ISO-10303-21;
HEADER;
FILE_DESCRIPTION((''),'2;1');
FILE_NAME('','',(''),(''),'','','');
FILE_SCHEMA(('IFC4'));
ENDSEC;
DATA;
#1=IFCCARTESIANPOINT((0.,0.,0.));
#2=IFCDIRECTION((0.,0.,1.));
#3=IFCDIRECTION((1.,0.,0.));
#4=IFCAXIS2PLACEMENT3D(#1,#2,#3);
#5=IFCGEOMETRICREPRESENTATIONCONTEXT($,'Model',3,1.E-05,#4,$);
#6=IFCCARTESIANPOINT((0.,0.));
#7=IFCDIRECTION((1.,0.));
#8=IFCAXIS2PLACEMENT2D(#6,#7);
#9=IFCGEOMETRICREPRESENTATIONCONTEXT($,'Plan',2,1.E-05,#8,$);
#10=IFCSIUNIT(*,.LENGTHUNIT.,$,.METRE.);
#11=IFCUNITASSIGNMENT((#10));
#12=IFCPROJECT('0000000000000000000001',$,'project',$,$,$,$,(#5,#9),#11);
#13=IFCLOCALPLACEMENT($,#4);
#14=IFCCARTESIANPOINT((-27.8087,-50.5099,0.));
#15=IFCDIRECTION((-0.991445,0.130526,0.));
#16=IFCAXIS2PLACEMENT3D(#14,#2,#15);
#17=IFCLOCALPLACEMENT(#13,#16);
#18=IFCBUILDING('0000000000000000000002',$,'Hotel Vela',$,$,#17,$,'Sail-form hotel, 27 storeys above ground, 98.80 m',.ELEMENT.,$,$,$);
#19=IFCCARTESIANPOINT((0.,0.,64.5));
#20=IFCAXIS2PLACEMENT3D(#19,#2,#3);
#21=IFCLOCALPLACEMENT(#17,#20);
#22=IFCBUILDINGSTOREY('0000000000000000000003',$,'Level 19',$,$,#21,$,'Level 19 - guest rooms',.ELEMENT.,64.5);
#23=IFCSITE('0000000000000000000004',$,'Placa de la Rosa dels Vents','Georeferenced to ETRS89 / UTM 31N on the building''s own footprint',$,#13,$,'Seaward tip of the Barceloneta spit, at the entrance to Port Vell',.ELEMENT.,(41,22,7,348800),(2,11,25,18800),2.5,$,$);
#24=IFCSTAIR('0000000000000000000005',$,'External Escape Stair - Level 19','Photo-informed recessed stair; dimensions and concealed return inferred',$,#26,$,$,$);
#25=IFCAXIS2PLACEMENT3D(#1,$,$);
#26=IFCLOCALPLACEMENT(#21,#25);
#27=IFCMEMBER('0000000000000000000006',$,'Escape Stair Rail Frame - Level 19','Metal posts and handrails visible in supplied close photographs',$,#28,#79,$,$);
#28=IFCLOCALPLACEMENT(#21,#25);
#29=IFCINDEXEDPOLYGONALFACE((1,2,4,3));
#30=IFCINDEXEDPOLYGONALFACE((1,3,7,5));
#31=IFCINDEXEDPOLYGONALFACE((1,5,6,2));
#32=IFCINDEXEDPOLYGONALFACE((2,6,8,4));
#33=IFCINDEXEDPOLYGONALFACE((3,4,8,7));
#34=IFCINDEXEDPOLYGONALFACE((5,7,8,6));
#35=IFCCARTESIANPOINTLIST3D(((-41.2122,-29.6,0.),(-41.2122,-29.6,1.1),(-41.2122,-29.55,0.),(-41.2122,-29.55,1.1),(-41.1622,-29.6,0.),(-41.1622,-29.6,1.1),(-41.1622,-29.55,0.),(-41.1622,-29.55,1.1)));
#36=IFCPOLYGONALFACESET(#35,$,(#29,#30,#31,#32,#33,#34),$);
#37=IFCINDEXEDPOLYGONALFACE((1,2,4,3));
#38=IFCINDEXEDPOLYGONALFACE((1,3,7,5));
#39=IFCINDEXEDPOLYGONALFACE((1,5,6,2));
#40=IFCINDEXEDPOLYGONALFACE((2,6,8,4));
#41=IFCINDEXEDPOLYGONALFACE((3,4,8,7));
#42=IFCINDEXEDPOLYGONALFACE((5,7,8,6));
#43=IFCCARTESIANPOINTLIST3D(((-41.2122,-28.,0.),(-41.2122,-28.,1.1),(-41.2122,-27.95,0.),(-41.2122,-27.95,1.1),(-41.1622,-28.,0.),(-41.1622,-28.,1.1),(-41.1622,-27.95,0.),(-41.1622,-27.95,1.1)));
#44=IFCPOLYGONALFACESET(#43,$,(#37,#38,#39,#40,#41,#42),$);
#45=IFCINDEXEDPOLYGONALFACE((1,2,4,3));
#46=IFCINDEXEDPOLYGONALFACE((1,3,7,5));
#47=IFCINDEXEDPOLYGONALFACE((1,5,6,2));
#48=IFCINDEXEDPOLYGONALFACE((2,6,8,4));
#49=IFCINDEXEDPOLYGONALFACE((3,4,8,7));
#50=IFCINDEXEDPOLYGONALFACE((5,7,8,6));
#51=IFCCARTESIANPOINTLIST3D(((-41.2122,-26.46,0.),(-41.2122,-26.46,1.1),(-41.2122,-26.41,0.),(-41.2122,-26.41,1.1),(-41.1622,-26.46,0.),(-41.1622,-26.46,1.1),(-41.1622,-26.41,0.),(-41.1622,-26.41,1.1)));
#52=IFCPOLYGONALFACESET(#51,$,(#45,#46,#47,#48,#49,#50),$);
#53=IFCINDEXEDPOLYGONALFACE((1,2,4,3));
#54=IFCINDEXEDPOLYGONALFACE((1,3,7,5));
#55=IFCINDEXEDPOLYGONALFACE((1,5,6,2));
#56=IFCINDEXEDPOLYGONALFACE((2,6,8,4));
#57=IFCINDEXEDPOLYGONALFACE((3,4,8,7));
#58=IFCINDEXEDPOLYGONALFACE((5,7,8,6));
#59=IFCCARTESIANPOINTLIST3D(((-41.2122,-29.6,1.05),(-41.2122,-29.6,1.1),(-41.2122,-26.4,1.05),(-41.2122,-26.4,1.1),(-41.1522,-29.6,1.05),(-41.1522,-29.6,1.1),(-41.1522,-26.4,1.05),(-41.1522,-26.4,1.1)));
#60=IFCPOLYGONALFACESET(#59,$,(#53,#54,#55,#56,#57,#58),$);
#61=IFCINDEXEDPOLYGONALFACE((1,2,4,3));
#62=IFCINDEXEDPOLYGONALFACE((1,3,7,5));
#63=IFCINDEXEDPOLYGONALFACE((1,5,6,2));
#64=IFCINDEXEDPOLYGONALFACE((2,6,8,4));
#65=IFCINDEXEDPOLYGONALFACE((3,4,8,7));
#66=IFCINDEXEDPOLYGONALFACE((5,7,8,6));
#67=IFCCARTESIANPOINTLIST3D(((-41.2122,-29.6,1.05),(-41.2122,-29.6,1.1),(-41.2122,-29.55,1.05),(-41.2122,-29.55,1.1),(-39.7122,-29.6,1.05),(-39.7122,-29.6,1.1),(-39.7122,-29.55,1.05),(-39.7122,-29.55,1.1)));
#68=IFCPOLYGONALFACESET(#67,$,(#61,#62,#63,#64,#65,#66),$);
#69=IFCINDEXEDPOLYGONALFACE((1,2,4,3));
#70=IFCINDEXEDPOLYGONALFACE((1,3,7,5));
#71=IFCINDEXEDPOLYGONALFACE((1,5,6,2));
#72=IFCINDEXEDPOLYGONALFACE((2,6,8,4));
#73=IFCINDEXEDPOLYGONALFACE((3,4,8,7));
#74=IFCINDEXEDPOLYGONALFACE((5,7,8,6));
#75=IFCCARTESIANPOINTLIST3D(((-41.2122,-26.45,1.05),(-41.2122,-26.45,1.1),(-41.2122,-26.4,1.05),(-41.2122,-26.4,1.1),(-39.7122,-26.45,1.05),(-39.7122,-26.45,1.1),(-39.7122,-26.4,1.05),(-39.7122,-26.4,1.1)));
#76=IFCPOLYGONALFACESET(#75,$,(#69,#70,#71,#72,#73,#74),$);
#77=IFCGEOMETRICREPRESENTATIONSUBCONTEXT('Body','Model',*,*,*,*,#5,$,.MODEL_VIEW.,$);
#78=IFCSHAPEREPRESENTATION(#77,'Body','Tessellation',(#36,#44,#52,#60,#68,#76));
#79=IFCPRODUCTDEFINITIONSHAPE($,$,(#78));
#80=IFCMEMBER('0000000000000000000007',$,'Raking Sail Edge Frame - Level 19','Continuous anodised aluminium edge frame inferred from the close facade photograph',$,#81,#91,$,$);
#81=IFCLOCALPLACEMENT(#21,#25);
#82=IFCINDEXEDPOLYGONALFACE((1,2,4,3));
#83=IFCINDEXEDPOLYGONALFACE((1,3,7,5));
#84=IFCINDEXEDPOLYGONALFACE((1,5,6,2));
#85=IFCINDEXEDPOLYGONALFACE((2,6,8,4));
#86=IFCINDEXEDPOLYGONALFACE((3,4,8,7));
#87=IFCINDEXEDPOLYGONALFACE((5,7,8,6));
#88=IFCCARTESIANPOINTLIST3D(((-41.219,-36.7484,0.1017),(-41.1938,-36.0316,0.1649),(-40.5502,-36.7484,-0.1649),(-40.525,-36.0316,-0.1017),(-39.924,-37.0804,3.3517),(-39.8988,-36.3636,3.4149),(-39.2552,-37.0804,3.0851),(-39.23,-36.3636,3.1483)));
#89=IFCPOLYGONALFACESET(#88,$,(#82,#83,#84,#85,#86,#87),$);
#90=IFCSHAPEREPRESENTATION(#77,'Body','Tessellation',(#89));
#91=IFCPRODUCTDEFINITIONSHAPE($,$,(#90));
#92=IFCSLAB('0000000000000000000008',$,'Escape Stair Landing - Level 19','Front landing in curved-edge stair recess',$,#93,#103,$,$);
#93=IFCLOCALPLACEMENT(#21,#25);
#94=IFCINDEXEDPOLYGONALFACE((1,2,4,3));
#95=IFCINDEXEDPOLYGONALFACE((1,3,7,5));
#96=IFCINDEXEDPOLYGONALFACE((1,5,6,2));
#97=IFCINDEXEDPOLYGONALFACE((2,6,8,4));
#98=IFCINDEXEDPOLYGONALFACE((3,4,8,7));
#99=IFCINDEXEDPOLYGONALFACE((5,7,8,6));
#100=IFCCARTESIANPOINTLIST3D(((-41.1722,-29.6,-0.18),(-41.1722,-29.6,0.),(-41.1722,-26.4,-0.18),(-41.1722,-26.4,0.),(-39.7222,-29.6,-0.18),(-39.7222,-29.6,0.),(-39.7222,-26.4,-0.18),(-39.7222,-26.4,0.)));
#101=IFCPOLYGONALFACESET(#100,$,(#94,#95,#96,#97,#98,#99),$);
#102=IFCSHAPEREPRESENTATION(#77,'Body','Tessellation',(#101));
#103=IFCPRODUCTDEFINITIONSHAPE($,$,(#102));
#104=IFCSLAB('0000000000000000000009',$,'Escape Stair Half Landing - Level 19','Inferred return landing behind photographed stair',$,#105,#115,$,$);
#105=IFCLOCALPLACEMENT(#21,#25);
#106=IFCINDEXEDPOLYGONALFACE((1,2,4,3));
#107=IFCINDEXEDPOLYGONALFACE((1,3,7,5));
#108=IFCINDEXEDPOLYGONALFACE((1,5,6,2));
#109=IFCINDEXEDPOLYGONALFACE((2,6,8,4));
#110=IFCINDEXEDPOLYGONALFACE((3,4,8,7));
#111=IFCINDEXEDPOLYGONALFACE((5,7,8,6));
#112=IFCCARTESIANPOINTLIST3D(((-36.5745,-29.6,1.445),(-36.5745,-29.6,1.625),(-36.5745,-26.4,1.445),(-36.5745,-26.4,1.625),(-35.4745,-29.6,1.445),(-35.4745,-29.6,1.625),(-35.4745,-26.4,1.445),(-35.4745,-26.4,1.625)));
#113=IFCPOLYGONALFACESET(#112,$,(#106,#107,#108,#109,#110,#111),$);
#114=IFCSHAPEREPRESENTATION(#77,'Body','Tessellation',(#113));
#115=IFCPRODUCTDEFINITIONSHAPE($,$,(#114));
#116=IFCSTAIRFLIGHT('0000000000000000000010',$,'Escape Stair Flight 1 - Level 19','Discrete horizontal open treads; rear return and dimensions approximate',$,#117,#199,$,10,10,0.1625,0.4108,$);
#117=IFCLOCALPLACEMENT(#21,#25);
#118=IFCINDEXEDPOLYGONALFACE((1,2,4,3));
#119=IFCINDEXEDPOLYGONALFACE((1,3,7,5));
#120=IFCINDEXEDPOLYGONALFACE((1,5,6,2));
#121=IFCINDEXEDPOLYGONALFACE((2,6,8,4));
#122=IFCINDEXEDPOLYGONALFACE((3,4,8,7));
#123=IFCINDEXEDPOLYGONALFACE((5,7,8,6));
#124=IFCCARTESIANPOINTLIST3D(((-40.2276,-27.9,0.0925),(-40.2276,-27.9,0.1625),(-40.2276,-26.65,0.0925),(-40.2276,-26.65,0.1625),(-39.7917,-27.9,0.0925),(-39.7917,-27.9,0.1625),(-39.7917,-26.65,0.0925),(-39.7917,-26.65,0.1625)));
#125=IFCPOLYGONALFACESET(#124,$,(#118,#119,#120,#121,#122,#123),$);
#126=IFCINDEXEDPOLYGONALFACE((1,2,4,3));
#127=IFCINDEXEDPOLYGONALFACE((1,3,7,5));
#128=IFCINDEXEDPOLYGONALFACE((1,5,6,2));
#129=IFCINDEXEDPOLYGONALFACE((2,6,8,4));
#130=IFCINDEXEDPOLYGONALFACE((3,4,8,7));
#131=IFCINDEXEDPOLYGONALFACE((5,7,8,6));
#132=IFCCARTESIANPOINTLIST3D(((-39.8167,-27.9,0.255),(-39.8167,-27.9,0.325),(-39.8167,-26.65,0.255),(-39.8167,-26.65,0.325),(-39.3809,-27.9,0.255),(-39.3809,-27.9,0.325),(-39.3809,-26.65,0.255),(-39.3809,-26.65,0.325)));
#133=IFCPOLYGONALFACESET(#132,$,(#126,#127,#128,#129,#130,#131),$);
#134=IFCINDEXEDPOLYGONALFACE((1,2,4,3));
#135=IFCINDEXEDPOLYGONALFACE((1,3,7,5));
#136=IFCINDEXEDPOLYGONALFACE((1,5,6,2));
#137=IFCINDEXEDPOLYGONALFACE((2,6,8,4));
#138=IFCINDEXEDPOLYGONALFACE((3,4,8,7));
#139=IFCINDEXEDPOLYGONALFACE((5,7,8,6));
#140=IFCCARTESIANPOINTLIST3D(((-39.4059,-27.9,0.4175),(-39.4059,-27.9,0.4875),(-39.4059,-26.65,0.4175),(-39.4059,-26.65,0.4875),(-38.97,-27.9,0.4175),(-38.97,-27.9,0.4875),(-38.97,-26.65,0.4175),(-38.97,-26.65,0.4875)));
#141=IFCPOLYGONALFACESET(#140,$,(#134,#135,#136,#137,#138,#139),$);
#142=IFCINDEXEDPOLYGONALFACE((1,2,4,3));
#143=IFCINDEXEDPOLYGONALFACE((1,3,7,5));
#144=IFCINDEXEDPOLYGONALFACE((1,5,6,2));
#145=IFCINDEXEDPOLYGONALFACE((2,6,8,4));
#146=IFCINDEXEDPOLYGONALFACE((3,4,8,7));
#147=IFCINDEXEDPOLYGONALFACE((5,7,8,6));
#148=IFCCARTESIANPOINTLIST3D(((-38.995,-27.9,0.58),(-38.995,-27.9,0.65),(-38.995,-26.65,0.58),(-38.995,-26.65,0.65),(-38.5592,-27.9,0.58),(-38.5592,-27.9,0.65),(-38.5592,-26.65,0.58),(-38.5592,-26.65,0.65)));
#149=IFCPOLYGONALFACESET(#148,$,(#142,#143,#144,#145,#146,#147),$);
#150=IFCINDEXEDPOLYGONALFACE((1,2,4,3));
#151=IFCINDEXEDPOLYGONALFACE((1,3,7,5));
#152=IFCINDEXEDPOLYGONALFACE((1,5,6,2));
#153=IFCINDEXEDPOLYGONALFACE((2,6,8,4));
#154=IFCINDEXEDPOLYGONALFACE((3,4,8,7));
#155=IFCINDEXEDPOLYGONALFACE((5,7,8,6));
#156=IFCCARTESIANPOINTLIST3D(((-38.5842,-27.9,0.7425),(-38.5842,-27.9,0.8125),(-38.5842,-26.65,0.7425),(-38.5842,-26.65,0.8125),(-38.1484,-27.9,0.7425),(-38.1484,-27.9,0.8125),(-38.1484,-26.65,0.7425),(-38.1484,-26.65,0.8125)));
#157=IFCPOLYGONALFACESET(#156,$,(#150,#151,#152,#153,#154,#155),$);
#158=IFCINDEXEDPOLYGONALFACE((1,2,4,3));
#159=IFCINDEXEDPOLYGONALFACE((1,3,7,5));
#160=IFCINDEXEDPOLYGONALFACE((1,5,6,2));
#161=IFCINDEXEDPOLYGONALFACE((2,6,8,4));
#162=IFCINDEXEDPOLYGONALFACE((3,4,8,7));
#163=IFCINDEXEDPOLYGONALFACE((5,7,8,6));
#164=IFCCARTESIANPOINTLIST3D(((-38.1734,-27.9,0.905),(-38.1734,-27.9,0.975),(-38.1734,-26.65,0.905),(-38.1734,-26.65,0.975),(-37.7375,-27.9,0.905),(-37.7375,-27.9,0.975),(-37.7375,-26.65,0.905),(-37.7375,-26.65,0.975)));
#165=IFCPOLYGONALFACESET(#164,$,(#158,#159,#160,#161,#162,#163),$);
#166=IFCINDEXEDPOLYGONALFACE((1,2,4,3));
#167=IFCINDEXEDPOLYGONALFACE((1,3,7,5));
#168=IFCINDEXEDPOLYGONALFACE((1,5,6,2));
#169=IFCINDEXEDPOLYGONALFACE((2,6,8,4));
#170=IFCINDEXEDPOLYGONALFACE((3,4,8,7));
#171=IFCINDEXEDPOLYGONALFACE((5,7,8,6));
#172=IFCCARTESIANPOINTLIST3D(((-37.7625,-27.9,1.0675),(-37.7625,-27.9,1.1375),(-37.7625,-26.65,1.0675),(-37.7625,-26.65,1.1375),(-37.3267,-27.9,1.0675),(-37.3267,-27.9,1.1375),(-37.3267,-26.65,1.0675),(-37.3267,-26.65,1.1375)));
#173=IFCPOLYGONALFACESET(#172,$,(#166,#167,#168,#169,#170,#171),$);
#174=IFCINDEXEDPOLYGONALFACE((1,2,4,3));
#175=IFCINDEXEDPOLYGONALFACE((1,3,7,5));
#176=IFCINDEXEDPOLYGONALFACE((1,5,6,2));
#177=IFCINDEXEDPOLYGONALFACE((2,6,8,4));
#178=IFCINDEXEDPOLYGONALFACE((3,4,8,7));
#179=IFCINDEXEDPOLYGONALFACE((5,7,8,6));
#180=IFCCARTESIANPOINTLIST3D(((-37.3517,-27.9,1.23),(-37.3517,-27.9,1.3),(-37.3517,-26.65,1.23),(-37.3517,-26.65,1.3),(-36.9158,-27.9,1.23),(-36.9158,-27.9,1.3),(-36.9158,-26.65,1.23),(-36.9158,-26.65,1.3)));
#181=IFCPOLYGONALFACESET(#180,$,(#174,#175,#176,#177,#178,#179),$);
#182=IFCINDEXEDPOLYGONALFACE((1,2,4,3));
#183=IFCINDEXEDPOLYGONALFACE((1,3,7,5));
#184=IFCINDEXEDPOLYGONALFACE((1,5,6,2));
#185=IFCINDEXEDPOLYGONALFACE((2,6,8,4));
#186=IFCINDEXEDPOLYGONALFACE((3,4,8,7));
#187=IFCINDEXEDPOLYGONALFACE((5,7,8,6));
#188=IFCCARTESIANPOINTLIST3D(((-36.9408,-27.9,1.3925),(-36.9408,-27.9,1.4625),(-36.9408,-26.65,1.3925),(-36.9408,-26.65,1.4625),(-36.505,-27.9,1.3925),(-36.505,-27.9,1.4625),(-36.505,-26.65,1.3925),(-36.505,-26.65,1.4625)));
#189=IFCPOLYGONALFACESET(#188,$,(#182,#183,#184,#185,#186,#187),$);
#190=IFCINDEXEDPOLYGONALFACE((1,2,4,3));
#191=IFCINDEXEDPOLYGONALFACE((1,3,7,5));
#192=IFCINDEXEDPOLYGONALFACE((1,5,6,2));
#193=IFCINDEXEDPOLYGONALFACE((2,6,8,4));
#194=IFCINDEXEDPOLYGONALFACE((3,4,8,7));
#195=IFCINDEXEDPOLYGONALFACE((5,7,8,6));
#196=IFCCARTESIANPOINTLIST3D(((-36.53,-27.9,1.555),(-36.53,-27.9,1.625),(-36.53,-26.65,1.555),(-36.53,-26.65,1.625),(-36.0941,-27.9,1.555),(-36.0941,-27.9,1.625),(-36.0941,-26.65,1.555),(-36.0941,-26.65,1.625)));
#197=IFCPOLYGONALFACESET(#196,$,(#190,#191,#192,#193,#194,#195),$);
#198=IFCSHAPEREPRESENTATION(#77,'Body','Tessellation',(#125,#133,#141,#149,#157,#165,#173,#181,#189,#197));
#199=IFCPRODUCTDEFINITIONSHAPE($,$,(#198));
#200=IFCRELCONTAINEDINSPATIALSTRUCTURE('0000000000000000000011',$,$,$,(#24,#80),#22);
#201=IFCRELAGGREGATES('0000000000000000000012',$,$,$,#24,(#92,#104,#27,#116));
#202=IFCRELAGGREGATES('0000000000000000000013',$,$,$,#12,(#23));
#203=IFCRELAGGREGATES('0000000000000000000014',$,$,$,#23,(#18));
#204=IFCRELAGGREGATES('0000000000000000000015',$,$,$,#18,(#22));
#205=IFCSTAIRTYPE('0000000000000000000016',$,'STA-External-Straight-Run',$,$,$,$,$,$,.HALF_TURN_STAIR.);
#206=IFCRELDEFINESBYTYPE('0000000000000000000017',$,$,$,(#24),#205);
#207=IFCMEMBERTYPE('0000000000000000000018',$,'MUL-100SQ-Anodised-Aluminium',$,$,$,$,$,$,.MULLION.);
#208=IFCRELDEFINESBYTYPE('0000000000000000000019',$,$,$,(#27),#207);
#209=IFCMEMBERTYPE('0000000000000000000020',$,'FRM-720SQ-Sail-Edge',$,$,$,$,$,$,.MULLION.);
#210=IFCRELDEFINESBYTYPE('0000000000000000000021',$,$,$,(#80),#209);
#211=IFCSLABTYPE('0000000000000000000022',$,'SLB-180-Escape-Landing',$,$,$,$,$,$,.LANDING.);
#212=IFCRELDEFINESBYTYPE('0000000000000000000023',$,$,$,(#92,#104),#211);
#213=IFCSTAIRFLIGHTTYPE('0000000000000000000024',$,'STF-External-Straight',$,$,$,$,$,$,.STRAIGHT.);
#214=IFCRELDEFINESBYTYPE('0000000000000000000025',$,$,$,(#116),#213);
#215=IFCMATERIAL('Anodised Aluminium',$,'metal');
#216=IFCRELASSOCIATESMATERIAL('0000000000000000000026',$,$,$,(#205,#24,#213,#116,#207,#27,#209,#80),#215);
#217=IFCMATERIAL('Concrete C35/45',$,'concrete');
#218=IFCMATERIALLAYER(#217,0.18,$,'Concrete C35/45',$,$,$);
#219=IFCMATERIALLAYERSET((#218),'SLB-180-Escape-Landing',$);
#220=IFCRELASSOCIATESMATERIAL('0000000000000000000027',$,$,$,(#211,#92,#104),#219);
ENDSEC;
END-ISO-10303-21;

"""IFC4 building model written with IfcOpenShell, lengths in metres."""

from ifc_helpers import new_model, si_unit, frame, origin_with_axes, origin_2d_with_axis, place, context, subcontext, project, spatial, line, indexed_curve, rectangle, outline, extrude, material, layer, layer_set, layer_usage, material_profile, profile_set, profile_usage, type_object, element, aggregate, save


model = new_model("IFC4")

# Units and contexts
model_context = context("Model", 3, precision=1e-05, world=origin_with_axes())
plan_context = context("Plan", 2, precision=1e-05, world=origin_2d_with_axis())
body_context = subcontext(model_context, "Body", "Model", "MODEL_VIEW")
ifc_project = project(units=[si_unit("LENGTHUNIT", "METRE")], contexts=[model_context, plan_context])

# Site, building, storey
site_placement = place(None, origin_with_axes())
site = spatial("IfcSite", under=ifc_project, at=site_placement, Name="Placa de la Rosa dels Vents", Description="Georeferenced to ETRS89 / UTM 31N on the building's own footprint", LongName="Seaward tip of the Barceloneta spit, at the entrance to Port Vell", CompositionType="ELEMENT", RefLatitude=(41, 22, 7, 348800), RefLongitude=(2, 11, 25, 18800), RefElevation=2.5)
building_placement = place(site_placement, frame((-27.8087, -50.5099, 0.0), z_axis=(0.0, 0.0, 1.0), x_axis=(-0.991445, 0.130526, 0.0)))
building = spatial("IfcBuilding", under=site, at=building_placement, Name="Hotel Vela", LongName="Sail-form hotel, 27 storeys above ground, 98.80 m", CompositionType="ELEMENT")
storey_placement = place(building_placement, frame((0.0, 0.0, 64.5), z_axis=(0.0, 0.0, 1.0), x_axis=(1.0, 0.0, 0.0)))
storey = spatial("IfcBuildingStorey", under=building, at=storey_placement, Name="Level 19", LongName="Level 19 - guest rooms", CompositionType="ELEMENT", Elevation=64.5)

# Stair, member
ifc_material_1 = material(Name="Anodised Aluminium", Category="metal")
stair_type = type_object("IfcStairType", Name="STA-External-Straight-Run", PredefinedType="HALF_TURN_STAIR", material=ifc_material_1)
stair_placement = place(storey_placement, frame((0.0, 0.0, -64.5), z_axis=(0.0, 0.0, 1.0), x_axis=(1.0, 0.0, 0.0)))
stair = element("IfcStair", 1, at=stair_placement, inside=storey, type_object=stair_type, material=ifc_material_1, Name="External Escape Stair - Level 19", Description="Photo-informed recessed stair; dimensions and concealed return inferred")
ifc_material_profile_1 = material_profile(ifc_material_1, rectangle(XDim=0.1, YDim=0.1))
ifc_profile_set_1 = profile_set([ifc_material_profile_1], Name="MUL-100SQ-Anodised-Aluminium")
ifc_profile_usage_1 = profile_usage(ifc_profile_set_1)
member_type_1 = type_object("IfcMemberType", Name="MUL-100SQ-Anodised-Aluminium", PredefinedType="MULLION", material=ifc_profile_set_1)
member_1_placement = place(stair_placement, origin_with_axes())
member_1 = element("IfcMember", 2, at=member_1_placement, type_object=member_type_1, material=ifc_profile_usage_1, Name="Escape Stair Rail Frame - Level 19", Description="Metal posts and handrails visible in supplied close photographs", context=body_context, shape_type="SweptSolid", body=[
    extrude(outline(indexed_curve([(0.0, 0.0), (0.05, 0.0), (0.05, 0.05), (0.0, 0.05)], segments=[line(1, 2, 3, 4, 1)])), frame((-41.2122, -29.6, 64.5), z_axis=(0.0, 0.0, 1.0), x_axis=(1.0, 0.0, 0.0)), (0.0, 0.0, 1.0), 1.1),
    extrude(outline(indexed_curve([(0.0, 0.0), (0.05, 0.0), (0.05, 0.05), (0.0, 0.05)], segments=[line(1, 2, 3, 4, 1)])), frame((-41.2122, -28.0, 64.5), z_axis=(0.0, 0.0, 1.0), x_axis=(1.0, 0.0, 0.0)), (0.0, 0.0, 1.0), 1.1),
    extrude(outline(indexed_curve([(0.0, 0.0), (0.05, 0.0), (0.05, 0.05), (0.0, 0.05)], segments=[line(1, 2, 3, 4, 1)])), frame((-41.2122, -26.46, 64.5), z_axis=(0.0, 0.0, 1.0), x_axis=(1.0, 0.0, 0.0)), (0.0, 0.0, 1.0), 1.1),
    extrude(outline(indexed_curve([(0.0, 0.0), (0.06, 0.0), (0.06, 3.2), (0.0, 3.2)], segments=[line(1, 2, 3, 4, 1)])), frame((-41.2122, -29.6, 65.55), z_axis=(0.0, 0.0, 1.0), x_axis=(1.0, 0.0, 0.0)), (0.0, 0.0, 1.0), 0.05),
    extrude(outline(indexed_curve([(0.0, 0.0), (1.5, 0.0), (1.5, 0.05), (0.0, 0.05)], segments=[line(1, 2, 3, 4, 1)])), frame((-41.2122, -29.6, 65.55), z_axis=(0.0, 0.0, 1.0), x_axis=(1.0, 0.0, 0.0)), (0.0, 0.0, 1.0), 0.05),
    extrude(outline(indexed_curve([(0.0, 0.0), (1.5, 0.0), (1.5, 0.05), (0.0, 0.05)], segments=[line(1, 2, 3, 4, 1)])), frame((-41.2122, -26.45, 65.55), z_axis=(0.0, 0.0, 1.0), x_axis=(1.0, 0.0, 0.0)), (0.0, 0.0, 1.0), 0.05),
])

# Member
ifc_material_profile_2 = material_profile(ifc_material_1, rectangle(XDim=0.72, YDim=0.72))
ifc_profile_set_2 = profile_set([ifc_material_profile_2], Name="FRM-720SQ-Sail-Edge")
ifc_profile_usage_2 = profile_usage(ifc_profile_set_2)
member_type_2 = type_object("IfcMemberType", Name="FRM-720SQ-Sail-Edge", PredefinedType="MULLION", material=ifc_profile_set_2)
member_2_placement = place(storey_placement, frame((-40.872, -36.39, 0.0), z_axis=(0.368503, -0.094473, 0.924814), x_axis=(0.928969, 0.0, -0.370158)))
element("IfcMember", 3, at=member_2_placement, inside=storey, type_object=member_type_2, material=ifc_profile_usage_2, Name="Raking Sail Edge Frame - Level 19", Description="Continuous anodised aluminium edge frame inferred from the close facade photograph", context=body_context, shape_type="SweptSolid", body=[
    extrude(outline(indexed_curve([(-0.36, -0.36), (0.36, -0.36), (0.36, 0.36), (-0.36, 0.36)], segments=[line(1, 2, 3, 4, 1)])), origin_with_axes(), (0.0, 0.0, 1.0), 3.5142),
])

# Slabs
ifc_material_2 = material(Name="Concrete C35/45", Category="concrete")
ifc_layer = layer(ifc_material_2, 0.18, Name="Concrete C35/45")
ifc_layer_set = layer_set([ifc_layer], Name="SLB-180-Escape-Landing")
ifc_layer_usage_1 = layer_usage(ifc_layer_set, "AXIS3", "POSITIVE", 0.0)
slab_type = type_object("IfcSlabType", Name="SLB-180-Escape-Landing", PredefinedType="LANDING", material=ifc_layer_set)
slab_1_placement = place(stair_placement, frame((-41.1722, -29.6, 64.32), z_axis=(0.0, 0.0, 1.0), x_axis=(1.0, 0.0, 0.0)))
slab_1 = element("IfcSlab", 4, at=slab_1_placement, type_object=slab_type, material=ifc_layer_usage_1, Name="Escape Stair Landing - Level 19", Description="Front landing in curved-edge stair recess", context=body_context, shape_type="SweptSolid", body=[
    extrude(outline(indexed_curve([(0.0, 0.0), (1.45, 0.0), (1.45, 3.2), (0.0, 3.2)], segments=[line(1, 2, 3, 4, 1)])), origin_with_axes(), (0.0, 0.0, 1.0), 0.18),
])
ifc_layer_usage_2 = layer_usage(ifc_layer_set, "AXIS3", "POSITIVE", 0.0)
slab_2_placement = place(stair_placement, frame((-36.5745, -29.6, 65.945), z_axis=(0.0, 0.0, 1.0), x_axis=(1.0, 0.0, 0.0)))
slab_2 = element("IfcSlab", 5, at=slab_2_placement, type_object=slab_type, material=ifc_layer_usage_2, Name="Escape Stair Half Landing - Level 19", Description="Inferred return landing behind photographed stair", context=body_context, shape_type="SweptSolid", body=[
    extrude(outline(indexed_curve([(0.0, 0.0), (1.1, 0.0), (1.1, 3.2), (0.0, 3.2)], segments=[line(1, 2, 3, 4, 1)])), origin_with_axes(), (0.0, 0.0, 1.0), 0.18),
])

# Stair flight
stair_flight_type = type_object("IfcStairFlightType", Name="STF-External-Straight", PredefinedType="STRAIGHT", material=ifc_material_1)
stair_flight_1_placement = place(stair_placement, origin_with_axes())
stair_flight_1 = element("IfcStairFlight", 6, at=stair_flight_1_placement, type_object=stair_flight_type, material=ifc_material_1, Name="Escape Stair Flight 1 - Level 19", Description="Discrete horizontal open treads; rear return and dimensions approximate", NumberOfRisers=10, NumberOfTreads=10, RiserHeight=0.1625, TreadLength=0.4108, context=body_context, shape_type="SweptSolid", body=[
    extrude(outline(indexed_curve([(0.0, 0.0), (0.4358, 0.0), (0.4358, 1.25), (0.0, 1.25)], segments=[line(1, 2, 3, 4, 1)])), frame((-40.2276, -27.9, 64.5925), z_axis=(0.0, 0.0, 1.0), x_axis=(1.0, 0.0, 0.0)), (0.0, 0.0, 1.0), 0.07),
    extrude(outline(indexed_curve([(0.0, 0.0), (0.4358, 0.0), (0.4358, 1.25), (0.0, 1.25)], segments=[line(1, 2, 3, 4, 1)])), frame((-39.8167, -27.9, 64.755), z_axis=(0.0, 0.0, 1.0), x_axis=(1.0, 0.0, 0.0)), (0.0, 0.0, 1.0), 0.07),
    extrude(outline(indexed_curve([(0.0, 0.0), (0.4358, 0.0), (0.4358, 1.25), (0.0, 1.25)], segments=[line(1, 2, 3, 4, 1)])), frame((-39.4059, -27.9, 64.9175), z_axis=(0.0, 0.0, 1.0), x_axis=(1.0, 0.0, 0.0)), (0.0, 0.0, 1.0), 0.07),
    extrude(outline(indexed_curve([(0.0, 0.0), (0.4358, 0.0), (0.4358, 1.25), (0.0, 1.25)], segments=[line(1, 2, 3, 4, 1)])), frame((-38.995, -27.9, 65.08), z_axis=(0.0, 0.0, 1.0), x_axis=(1.0, 0.0, 0.0)), (0.0, 0.0, 1.0), 0.07),
    extrude(outline(indexed_curve([(0.0, 0.0), (0.4358, 0.0), (0.4358, 1.25), (0.0, 1.25)], segments=[line(1, 2, 3, 4, 1)])), frame((-38.5842, -27.9, 65.2425), z_axis=(0.0, 0.0, 1.0), x_axis=(1.0, 0.0, 0.0)), (0.0, 0.0, 1.0), 0.07),
    extrude(outline(indexed_curve([(0.0, 0.0), (0.4358, 0.0), (0.4358, 1.25), (0.0, 1.25)], segments=[line(1, 2, 3, 4, 1)])), frame((-38.1734, -27.9, 65.405), z_axis=(0.0, 0.0, 1.0), x_axis=(1.0, 0.0, 0.0)), (0.0, 0.0, 1.0), 0.07),
    extrude(outline(indexed_curve([(0.0, 0.0), (0.4358, 0.0), (0.4358, 1.25), (0.0, 1.25)], segments=[line(1, 2, 3, 4, 1)])), frame((-37.7625, -27.9, 65.5675), z_axis=(0.0, 0.0, 1.0), x_axis=(1.0, 0.0, 0.0)), (0.0, 0.0, 1.0), 0.07),
    extrude(outline(indexed_curve([(0.0, 0.0), (0.4358, 0.0), (0.4358, 1.25), (0.0, 1.25)], segments=[line(1, 2, 3, 4, 1)])), frame((-37.3517, -27.9, 65.73), z_axis=(0.0, 0.0, 1.0), x_axis=(1.0, 0.0, 0.0)), (0.0, 0.0, 1.0), 0.07),
    extrude(outline(indexed_curve([(0.0, 0.0), (0.4358, 0.0), (0.4358, 1.25), (0.0, 1.25)], segments=[line(1, 2, 3, 4, 1)])), frame((-36.9408, -27.9, 65.8925), z_axis=(0.0, 0.0, 1.0), x_axis=(1.0, 0.0, 0.0)), (0.0, 0.0, 1.0), 0.07),
    extrude(outline(indexed_curve([(0.0, 0.0), (0.4358, 0.0), (0.4358, 1.25), (0.0, 1.25)], segments=[line(1, 2, 3, 4, 1)])), frame((-36.53, -27.9, 66.055), z_axis=(0.0, 0.0, 1.0), x_axis=(1.0, 0.0, 0.0)), (0.0, 0.0, 1.0), 0.07),
])

aggregate(stair, [slab_1, slab_2, member_1, stair_flight_1])

save(model, "model.ifc")
